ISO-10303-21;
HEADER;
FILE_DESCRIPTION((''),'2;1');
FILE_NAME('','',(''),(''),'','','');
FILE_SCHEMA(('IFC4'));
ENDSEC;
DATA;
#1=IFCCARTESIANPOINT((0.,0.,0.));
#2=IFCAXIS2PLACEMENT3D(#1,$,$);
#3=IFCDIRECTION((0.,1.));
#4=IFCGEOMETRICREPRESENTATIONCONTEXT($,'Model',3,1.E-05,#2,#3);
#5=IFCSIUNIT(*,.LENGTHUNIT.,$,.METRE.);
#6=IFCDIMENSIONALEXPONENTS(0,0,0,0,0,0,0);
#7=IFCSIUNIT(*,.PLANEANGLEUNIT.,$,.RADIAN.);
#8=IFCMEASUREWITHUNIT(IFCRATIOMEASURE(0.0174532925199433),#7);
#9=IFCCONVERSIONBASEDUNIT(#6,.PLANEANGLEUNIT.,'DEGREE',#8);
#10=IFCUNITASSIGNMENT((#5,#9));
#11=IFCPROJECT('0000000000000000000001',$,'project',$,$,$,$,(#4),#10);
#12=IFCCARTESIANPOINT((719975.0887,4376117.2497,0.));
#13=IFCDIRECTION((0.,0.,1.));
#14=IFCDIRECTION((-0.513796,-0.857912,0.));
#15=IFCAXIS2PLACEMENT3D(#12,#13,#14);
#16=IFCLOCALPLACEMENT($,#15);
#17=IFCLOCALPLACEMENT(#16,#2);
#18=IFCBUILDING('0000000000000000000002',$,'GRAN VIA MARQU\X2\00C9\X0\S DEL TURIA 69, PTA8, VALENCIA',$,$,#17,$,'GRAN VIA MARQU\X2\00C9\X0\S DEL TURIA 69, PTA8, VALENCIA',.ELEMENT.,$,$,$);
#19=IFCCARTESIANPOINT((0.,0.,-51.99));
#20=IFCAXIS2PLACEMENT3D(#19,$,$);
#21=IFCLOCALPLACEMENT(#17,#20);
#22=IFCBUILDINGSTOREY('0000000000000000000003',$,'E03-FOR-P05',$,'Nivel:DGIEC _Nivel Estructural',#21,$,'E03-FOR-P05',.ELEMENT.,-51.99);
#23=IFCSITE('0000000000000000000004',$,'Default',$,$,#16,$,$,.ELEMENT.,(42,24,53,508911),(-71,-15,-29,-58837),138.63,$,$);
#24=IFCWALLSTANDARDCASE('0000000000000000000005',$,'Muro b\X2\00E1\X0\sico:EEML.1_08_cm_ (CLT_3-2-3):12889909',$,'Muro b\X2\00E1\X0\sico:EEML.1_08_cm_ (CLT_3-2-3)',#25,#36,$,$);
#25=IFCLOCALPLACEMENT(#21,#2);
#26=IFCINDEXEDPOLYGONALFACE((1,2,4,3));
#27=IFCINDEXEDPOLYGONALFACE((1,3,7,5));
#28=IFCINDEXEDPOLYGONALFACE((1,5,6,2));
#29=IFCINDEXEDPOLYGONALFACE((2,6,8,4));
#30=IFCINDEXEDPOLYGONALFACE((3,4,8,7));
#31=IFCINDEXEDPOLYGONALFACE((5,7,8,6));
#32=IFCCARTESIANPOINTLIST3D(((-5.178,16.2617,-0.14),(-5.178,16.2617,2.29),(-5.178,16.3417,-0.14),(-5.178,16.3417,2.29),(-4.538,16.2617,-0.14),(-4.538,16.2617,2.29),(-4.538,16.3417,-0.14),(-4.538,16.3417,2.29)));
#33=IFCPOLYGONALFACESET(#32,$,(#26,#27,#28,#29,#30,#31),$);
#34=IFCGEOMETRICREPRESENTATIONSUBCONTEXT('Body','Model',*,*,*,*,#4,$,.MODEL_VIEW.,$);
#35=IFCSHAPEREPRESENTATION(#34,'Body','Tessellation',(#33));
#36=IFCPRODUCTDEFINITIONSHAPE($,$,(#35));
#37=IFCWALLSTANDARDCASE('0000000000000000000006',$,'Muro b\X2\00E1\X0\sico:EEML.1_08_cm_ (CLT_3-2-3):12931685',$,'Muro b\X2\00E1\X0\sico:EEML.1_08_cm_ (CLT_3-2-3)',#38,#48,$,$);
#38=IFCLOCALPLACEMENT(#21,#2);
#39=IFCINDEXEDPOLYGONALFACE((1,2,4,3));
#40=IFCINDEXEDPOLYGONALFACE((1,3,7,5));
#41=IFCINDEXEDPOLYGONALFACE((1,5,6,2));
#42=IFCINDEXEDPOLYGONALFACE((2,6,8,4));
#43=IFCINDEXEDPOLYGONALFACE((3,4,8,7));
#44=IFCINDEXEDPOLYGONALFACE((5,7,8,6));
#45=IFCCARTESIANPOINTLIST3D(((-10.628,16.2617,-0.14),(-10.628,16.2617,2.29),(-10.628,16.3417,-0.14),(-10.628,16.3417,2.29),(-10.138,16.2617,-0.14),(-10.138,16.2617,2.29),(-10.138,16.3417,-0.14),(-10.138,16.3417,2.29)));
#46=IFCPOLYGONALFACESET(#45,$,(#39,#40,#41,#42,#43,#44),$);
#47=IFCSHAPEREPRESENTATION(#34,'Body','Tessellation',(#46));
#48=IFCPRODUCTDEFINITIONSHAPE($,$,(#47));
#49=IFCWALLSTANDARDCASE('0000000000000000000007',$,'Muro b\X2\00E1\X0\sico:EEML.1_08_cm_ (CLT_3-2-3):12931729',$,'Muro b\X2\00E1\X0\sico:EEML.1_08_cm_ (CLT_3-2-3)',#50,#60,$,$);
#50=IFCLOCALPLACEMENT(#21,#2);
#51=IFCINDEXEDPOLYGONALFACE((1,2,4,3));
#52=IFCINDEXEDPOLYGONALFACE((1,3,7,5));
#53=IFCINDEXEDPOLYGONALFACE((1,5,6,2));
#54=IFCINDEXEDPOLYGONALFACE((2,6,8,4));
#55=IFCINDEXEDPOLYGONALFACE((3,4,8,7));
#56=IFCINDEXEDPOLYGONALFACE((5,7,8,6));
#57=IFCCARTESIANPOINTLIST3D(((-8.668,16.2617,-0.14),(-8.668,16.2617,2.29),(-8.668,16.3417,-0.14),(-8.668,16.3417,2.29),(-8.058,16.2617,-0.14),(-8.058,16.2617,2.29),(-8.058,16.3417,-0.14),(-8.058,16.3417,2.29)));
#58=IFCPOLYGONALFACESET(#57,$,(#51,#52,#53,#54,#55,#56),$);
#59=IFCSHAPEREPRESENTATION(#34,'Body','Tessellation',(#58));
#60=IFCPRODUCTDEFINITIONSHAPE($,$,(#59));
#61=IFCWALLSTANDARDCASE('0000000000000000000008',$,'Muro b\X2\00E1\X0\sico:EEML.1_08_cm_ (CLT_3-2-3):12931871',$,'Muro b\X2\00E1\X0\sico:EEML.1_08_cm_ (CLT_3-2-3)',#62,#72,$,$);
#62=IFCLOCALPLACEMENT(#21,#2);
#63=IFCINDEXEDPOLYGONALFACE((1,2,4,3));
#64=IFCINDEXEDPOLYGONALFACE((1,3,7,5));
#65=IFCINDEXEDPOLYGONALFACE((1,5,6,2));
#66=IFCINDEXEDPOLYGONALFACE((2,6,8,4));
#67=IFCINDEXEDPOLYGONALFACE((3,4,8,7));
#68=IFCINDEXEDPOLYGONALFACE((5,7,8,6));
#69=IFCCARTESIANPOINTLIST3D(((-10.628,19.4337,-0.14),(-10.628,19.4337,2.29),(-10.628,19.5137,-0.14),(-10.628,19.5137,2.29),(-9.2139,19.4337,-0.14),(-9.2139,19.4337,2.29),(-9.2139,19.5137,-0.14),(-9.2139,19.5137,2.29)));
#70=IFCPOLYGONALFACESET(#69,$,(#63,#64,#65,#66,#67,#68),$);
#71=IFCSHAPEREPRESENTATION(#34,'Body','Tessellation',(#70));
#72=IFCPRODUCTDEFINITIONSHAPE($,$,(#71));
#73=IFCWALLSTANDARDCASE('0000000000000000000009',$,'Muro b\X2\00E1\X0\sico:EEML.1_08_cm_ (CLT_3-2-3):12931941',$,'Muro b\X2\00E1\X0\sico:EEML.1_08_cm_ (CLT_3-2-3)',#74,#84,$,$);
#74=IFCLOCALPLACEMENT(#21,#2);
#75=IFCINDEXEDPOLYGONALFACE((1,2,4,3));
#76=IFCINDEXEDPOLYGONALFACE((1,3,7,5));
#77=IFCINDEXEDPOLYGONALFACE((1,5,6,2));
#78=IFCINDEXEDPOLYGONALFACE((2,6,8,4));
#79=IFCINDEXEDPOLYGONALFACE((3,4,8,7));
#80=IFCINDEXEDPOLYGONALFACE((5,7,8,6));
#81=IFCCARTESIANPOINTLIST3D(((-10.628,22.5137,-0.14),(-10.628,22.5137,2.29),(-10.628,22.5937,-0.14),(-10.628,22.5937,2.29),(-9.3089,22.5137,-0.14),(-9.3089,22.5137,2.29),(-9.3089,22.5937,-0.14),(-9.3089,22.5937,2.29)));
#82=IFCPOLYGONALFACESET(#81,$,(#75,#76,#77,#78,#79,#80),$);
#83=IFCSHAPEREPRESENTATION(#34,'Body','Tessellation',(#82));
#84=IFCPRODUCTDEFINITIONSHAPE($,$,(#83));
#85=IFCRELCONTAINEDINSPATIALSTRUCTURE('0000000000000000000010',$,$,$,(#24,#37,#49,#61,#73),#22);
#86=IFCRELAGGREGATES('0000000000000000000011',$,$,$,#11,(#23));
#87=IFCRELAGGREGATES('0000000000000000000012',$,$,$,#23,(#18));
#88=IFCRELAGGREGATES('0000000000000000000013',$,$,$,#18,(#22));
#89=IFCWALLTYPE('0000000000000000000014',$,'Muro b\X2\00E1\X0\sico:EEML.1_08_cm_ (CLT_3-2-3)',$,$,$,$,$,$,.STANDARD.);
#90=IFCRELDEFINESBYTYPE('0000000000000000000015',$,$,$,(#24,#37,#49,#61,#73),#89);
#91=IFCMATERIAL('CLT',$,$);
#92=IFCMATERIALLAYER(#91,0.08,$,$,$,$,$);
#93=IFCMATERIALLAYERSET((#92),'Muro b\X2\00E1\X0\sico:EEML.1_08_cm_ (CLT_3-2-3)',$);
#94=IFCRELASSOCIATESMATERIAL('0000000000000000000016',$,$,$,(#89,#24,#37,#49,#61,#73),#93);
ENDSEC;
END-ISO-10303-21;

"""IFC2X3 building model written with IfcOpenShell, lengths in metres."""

from ifc_helpers import new_model, entity, si_unit, converted_unit, direction, frame, frame_2d, origin, place, context, subcontext, project, spatial, rectangle, extrude, material, layer, layer_set, layer_usage, type_object, element, save


model = new_model("IFC2X3")

# Units and contexts
model_context = context("Model", 3, precision=1e-05, world=origin(), true_north=direction((0.0, 1.0)))
body_context = subcontext(model_context, "Body", "Model", "MODEL_VIEW")
ifc_project = project(units=[si_unit("LENGTHUNIT", "METRE"), converted_unit("PLANEANGLEUNIT", "DEGREE", entity("IfcRatioMeasure", 0.0174532925199433), si_unit("PLANEANGLEUNIT", "RADIAN"), dimensions=[0, 0, 0, 0, 0, 0, 0])], contexts=[model_context])

# Site, building, storey
site_placement = place(None, frame((719975.0887, 4376117.2497, 0.0), z_axis=(0.0, 0.0, 1.0), x_axis=(-0.513796, -0.857912, 0.0)))
site = spatial("IfcSite", under=ifc_project, at=site_placement, Name="Default", CompositionType="ELEMENT", RefLatitude=(42, 24, 53, 508911), RefLongitude=(-71, -15, -29, -58837), RefElevation=138.63)
building_placement = place(site_placement, origin())
building = spatial("IfcBuilding", under=site, at=building_placement, Name="GRAN VIA MARQUÉS DEL TURIA 69, PTA8, VALENCIA", LongName="GRAN VIA MARQUÉS DEL TURIA 69, PTA8, VALENCIA", CompositionType="ELEMENT")
storey_placement = place(building_placement, frame((0.0, 0.0, -51.99)))
storey = spatial("IfcBuildingStorey", under=building, at=storey_placement, Name="E03-FOR-P05", ObjectType="Nivel:DGIEC _Nivel Estructural", LongName="E03-FOR-P05", CompositionType="ELEMENT", Elevation=-51.99)

# Shared definitions
ifc_material = material(Name="CLT")

# Walls
ifc_layer_1 = layer(ifc_material, 0.08)
ifc_layer_set_1 = layer_set([ifc_layer_1], Name="Muro básico:EEML.1_08_cm_ (CLT_3-2-3)")
ifc_layer_usage_1 = layer_usage(ifc_layer_set_1, "AXIS2", "NEGATIVE", 0.04)
wall_type_1 = type_object("IfcWallType", Name="Muro básico:EEML.1_08_cm_ (CLT_3-2-3)", PredefinedType="STANDARD", material=ifc_layer_set_1)
wall_1_placement = place(storey_placement, frame((-4.538, 16.3017, -0.14), z_axis=(0.0, 0.0, 1.0), x_axis=(-1.0, 0.0, 0.0)))
element("IfcWallStandardCase", 1, at=wall_1_placement, inside=storey, type_object=wall_type_1, material=ifc_layer_usage_1, Name="Muro básico:EEML.1_08_cm_ (CLT_3-2-3):12889909", ObjectType="Muro básico:EEML.1_08_cm_ (CLT_3-2-3)", context=body_context, shape_type="SweptSolid", body=[
    extrude(rectangle(XDim=0.64, YDim=0.08, at=frame_2d((0.32, 0.0), x_axis=(-1.0, 0.0))), origin(), (0.0, 0.0, 1.0), 2.43),
])
ifc_layer_usage_2 = layer_usage(ifc_layer_set_1, "AXIS2", "NEGATIVE", 0.04)
wall_2_placement = place(storey_placement, frame((-10.138, 16.3017, -0.14), z_axis=(0.0, 0.0, 1.0), x_axis=(-1.0, 0.0, 0.0)))
element("IfcWallStandardCase", 2, at=wall_2_placement, inside=storey, type_object=wall_type_1, material=ifc_layer_usage_2, Name="Muro básico:EEML.1_08_cm_ (CLT_3-2-3):12931685", ObjectType="Muro básico:EEML.1_08_cm_ (CLT_3-2-3)", context=body_context, shape_type="SweptSolid", body=[
    extrude(rectangle(XDim=0.49, YDim=0.08, at=frame_2d((0.245, 0.0), x_axis=(-1.0, 0.0))), origin(), (0.0, 0.0, 1.0), 2.43),
])
ifc_layer_usage_3 = layer_usage(ifc_layer_set_1, "AXIS2", "NEGATIVE", 0.04)
wall_3_placement = place(storey_placement, frame((-8.058, 16.3017, -0.14), z_axis=(0.0, 0.0, 1.0), x_axis=(-1.0, 0.0, 0.0)))
element("IfcWallStandardCase", 3, at=wall_3_placement, inside=storey, type_object=wall_type_1, material=ifc_layer_usage_3, Name="Muro básico:EEML.1_08_cm_ (CLT_3-2-3):12931729", ObjectType="Muro básico:EEML.1_08_cm_ (CLT_3-2-3)", context=body_context, shape_type="SweptSolid", body=[
    extrude(rectangle(XDim=0.61, YDim=0.08, at=frame_2d((0.305, 0.0), x_axis=(-1.0, 0.0))), origin(), (0.0, 0.0, 1.0), 2.43),
])
ifc_layer_usage_4 = layer_usage(ifc_layer_set_1, "AXIS2", "NEGATIVE", 0.04)
wall_4_placement = place(storey_placement, frame((-9.2139, 19.4737, -0.14), z_axis=(0.0, 0.0, 1.0), x_axis=(-1.0, 0.0, 0.0)))
element("IfcWallStandardCase", 4, at=wall_4_placement, inside=storey, type_object=wall_type_1, material=ifc_layer_usage_4, Name="Muro básico:EEML.1_08_cm_ (CLT_3-2-3):12931871", ObjectType="Muro básico:EEML.1_08_cm_ (CLT_3-2-3)", context=body_context, shape_type="SweptSolid", body=[
    extrude(rectangle(XDim=1.4142, YDim=0.08, at=frame_2d((0.7071, 0.0), x_axis=(-1.0, 0.0))), origin(), (0.0, 0.0, 1.0), 2.43),
])
ifc_layer_usage_5 = layer_usage(ifc_layer_set_1, "AXIS2", "NEGATIVE", 0.04)
wall_5_placement = place(storey_placement, frame((-9.3089, 22.5537, -0.14), z_axis=(0.0, 0.0, 1.0), x_axis=(-1.0, 0.0, 0.0)))
element("IfcWallStandardCase", 5, at=wall_5_placement, inside=storey, type_object=wall_type_1, material=ifc_layer_usage_5, Name="Muro básico:EEML.1_08_cm_ (CLT_3-2-3):12931941", ObjectType="Muro básico:EEML.1_08_cm_ (CLT_3-2-3)", context=body_context, shape_type="SweptSolid", body=[
    extrude(rectangle(XDim=1.3192, YDim=0.08, at=frame_2d((0.6596, 0.0), x_axis=(-1.0, 0.0))), origin(), (0.0, 0.0, 1.0), 2.43),
])

save(model, "model.ifc")
